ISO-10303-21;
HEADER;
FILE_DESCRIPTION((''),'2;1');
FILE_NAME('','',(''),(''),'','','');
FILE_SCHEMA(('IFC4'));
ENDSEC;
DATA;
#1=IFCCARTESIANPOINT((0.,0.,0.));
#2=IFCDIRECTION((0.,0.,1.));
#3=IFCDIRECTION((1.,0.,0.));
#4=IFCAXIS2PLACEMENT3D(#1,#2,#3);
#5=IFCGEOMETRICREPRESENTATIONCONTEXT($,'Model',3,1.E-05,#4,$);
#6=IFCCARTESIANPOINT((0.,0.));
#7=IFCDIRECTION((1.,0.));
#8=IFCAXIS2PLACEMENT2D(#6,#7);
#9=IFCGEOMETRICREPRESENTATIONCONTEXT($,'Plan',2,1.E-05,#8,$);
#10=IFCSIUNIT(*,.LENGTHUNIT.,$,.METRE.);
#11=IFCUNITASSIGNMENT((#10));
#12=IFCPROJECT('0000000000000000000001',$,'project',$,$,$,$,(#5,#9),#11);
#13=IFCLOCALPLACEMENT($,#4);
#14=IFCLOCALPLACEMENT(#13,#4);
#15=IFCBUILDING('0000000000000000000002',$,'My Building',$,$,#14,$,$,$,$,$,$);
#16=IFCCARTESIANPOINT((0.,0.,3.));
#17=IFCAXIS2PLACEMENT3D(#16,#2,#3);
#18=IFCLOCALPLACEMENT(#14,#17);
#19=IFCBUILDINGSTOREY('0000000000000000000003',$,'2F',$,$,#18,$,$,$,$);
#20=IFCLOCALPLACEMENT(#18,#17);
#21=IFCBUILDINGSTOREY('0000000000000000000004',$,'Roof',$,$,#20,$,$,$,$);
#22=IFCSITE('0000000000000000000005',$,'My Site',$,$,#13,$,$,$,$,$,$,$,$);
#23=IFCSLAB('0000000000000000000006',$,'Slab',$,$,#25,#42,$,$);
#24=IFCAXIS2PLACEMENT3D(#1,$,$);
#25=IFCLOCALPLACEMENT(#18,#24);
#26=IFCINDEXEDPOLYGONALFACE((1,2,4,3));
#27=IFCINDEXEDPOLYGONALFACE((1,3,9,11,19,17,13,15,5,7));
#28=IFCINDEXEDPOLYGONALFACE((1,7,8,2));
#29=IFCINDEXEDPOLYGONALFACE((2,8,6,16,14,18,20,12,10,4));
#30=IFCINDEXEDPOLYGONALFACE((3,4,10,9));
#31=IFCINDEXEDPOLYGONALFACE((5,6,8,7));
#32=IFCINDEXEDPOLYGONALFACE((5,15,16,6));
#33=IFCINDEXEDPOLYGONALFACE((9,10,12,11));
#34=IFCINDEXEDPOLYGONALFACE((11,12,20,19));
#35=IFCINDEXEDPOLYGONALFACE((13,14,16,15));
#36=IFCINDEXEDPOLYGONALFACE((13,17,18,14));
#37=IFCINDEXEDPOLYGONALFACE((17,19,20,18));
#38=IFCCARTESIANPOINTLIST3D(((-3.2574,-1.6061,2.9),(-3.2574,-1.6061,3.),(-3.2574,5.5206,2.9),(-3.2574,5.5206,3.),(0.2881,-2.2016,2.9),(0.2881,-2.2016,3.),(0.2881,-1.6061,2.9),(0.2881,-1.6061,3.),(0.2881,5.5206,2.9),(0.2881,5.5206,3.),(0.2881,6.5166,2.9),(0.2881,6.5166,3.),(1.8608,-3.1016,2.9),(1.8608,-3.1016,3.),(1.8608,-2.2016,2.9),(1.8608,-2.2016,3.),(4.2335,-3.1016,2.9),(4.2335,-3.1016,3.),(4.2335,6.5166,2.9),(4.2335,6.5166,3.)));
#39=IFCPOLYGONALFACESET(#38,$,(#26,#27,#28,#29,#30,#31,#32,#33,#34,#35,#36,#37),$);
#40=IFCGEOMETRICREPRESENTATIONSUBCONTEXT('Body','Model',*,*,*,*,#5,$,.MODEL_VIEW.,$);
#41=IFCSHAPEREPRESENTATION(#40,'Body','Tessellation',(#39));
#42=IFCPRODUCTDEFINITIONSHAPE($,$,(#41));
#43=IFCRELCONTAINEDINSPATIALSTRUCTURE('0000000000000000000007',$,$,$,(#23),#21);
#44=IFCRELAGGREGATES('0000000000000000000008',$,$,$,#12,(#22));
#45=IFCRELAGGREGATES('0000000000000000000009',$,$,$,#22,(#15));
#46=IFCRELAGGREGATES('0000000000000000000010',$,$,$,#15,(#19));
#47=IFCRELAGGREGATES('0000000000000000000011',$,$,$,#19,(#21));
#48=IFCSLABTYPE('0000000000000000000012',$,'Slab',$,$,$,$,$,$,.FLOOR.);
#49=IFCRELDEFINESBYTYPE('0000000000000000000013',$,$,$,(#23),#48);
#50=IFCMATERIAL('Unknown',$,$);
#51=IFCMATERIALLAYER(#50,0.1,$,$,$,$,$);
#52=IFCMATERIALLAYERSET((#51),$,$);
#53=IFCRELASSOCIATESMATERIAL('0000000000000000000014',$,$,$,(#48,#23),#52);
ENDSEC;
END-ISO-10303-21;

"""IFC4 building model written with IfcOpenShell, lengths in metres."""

from ifc_helpers import new_model, si_unit, frame, origin_with_axes, origin_2d_with_axis, place, context, subcontext, project, spatial, indexed_curve, outline, extrude, material, layer, layer_set, layer_usage, type_object, element, save


model = new_model("IFC4")

# Units and contexts
model_context = context("Model", 3, precision=1e-05, world=origin_with_axes())
plan_context = context("Plan", 2, precision=1e-05, world=origin_2d_with_axis())
body_context = subcontext(model_context, "Body", "Model", "MODEL_VIEW")
ifc_project = project(units=[si_unit("LENGTHUNIT", "METRE")], contexts=[model_context, plan_context])

# Site, building, storeys
site_placement = place(None, origin_with_axes())
site = spatial("IfcSite", under=ifc_project, at=site_placement, Name="My Site")
building_placement = place(site_placement, origin_with_axes())
building = spatial("IfcBuilding", under=site, at=building_placement, Name="My Building")
storey_1_placement = place(building_placement, frame((0.0, 0.0, 3.0), z_axis=(0.0, 0.0, 1.0), x_axis=(1.0, 0.0, 0.0)))
storey_1 = spatial("IfcBuildingStorey", under=building, at=storey_1_placement, Name="2F")
storey_2_placement = place(storey_1_placement, frame((0.0, 0.0, 3.0), z_axis=(0.0, 0.0, 1.0), x_axis=(1.0, 0.0, 0.0)))
storey_2 = spatial("IfcBuildingStorey", under=storey_1, at=storey_2_placement, Name="Roof")

# Slab
ifc_material = material(Name="Unknown")
ifc_layer = layer(ifc_material, 0.1)
ifc_layer_set = layer_set([ifc_layer])
ifc_layer_usage = layer_usage(ifc_layer_set, "AXIS3", "POSITIVE", -0.1)
slab_type = type_object("IfcSlabType", Name="Slab", PredefinedType="FLOOR", material=ifc_layer_set)
slab_placement = place(storey_2_placement, frame((4.2335, 6.5166, 0.0), z_axis=(0.0, 0.0, 1.0), x_axis=(1.0, 0.0, 0.0)))
element("IfcSlab", 1, at=slab_placement, inside=storey_2, type_object=slab_type, material=ifc_layer_usage, Name="Slab", context=body_context, shape_type="SweptSolid", body=[
    extrude(outline(indexed_curve([(0.0, 0.0), (-3.9454, 0.0), (-3.9454, -0.9959), (-7.4909, -0.9959), (-7.4909, -8.1227), (-3.9454, -8.1227), (-3.9454, -8.7182), (-2.3727, -8.7182), (-2.3727, -9.6182), (0.0, -9.6182), (0.0, 0.0)])), frame((0.0, 0.0, -0.1), z_axis=(0.0, 0.0, 1.0), x_axis=(1.0, 0.0, 0.0)), (0.0, 0.0, 1.0), 0.1),
])

save(model, "model.ifc")
